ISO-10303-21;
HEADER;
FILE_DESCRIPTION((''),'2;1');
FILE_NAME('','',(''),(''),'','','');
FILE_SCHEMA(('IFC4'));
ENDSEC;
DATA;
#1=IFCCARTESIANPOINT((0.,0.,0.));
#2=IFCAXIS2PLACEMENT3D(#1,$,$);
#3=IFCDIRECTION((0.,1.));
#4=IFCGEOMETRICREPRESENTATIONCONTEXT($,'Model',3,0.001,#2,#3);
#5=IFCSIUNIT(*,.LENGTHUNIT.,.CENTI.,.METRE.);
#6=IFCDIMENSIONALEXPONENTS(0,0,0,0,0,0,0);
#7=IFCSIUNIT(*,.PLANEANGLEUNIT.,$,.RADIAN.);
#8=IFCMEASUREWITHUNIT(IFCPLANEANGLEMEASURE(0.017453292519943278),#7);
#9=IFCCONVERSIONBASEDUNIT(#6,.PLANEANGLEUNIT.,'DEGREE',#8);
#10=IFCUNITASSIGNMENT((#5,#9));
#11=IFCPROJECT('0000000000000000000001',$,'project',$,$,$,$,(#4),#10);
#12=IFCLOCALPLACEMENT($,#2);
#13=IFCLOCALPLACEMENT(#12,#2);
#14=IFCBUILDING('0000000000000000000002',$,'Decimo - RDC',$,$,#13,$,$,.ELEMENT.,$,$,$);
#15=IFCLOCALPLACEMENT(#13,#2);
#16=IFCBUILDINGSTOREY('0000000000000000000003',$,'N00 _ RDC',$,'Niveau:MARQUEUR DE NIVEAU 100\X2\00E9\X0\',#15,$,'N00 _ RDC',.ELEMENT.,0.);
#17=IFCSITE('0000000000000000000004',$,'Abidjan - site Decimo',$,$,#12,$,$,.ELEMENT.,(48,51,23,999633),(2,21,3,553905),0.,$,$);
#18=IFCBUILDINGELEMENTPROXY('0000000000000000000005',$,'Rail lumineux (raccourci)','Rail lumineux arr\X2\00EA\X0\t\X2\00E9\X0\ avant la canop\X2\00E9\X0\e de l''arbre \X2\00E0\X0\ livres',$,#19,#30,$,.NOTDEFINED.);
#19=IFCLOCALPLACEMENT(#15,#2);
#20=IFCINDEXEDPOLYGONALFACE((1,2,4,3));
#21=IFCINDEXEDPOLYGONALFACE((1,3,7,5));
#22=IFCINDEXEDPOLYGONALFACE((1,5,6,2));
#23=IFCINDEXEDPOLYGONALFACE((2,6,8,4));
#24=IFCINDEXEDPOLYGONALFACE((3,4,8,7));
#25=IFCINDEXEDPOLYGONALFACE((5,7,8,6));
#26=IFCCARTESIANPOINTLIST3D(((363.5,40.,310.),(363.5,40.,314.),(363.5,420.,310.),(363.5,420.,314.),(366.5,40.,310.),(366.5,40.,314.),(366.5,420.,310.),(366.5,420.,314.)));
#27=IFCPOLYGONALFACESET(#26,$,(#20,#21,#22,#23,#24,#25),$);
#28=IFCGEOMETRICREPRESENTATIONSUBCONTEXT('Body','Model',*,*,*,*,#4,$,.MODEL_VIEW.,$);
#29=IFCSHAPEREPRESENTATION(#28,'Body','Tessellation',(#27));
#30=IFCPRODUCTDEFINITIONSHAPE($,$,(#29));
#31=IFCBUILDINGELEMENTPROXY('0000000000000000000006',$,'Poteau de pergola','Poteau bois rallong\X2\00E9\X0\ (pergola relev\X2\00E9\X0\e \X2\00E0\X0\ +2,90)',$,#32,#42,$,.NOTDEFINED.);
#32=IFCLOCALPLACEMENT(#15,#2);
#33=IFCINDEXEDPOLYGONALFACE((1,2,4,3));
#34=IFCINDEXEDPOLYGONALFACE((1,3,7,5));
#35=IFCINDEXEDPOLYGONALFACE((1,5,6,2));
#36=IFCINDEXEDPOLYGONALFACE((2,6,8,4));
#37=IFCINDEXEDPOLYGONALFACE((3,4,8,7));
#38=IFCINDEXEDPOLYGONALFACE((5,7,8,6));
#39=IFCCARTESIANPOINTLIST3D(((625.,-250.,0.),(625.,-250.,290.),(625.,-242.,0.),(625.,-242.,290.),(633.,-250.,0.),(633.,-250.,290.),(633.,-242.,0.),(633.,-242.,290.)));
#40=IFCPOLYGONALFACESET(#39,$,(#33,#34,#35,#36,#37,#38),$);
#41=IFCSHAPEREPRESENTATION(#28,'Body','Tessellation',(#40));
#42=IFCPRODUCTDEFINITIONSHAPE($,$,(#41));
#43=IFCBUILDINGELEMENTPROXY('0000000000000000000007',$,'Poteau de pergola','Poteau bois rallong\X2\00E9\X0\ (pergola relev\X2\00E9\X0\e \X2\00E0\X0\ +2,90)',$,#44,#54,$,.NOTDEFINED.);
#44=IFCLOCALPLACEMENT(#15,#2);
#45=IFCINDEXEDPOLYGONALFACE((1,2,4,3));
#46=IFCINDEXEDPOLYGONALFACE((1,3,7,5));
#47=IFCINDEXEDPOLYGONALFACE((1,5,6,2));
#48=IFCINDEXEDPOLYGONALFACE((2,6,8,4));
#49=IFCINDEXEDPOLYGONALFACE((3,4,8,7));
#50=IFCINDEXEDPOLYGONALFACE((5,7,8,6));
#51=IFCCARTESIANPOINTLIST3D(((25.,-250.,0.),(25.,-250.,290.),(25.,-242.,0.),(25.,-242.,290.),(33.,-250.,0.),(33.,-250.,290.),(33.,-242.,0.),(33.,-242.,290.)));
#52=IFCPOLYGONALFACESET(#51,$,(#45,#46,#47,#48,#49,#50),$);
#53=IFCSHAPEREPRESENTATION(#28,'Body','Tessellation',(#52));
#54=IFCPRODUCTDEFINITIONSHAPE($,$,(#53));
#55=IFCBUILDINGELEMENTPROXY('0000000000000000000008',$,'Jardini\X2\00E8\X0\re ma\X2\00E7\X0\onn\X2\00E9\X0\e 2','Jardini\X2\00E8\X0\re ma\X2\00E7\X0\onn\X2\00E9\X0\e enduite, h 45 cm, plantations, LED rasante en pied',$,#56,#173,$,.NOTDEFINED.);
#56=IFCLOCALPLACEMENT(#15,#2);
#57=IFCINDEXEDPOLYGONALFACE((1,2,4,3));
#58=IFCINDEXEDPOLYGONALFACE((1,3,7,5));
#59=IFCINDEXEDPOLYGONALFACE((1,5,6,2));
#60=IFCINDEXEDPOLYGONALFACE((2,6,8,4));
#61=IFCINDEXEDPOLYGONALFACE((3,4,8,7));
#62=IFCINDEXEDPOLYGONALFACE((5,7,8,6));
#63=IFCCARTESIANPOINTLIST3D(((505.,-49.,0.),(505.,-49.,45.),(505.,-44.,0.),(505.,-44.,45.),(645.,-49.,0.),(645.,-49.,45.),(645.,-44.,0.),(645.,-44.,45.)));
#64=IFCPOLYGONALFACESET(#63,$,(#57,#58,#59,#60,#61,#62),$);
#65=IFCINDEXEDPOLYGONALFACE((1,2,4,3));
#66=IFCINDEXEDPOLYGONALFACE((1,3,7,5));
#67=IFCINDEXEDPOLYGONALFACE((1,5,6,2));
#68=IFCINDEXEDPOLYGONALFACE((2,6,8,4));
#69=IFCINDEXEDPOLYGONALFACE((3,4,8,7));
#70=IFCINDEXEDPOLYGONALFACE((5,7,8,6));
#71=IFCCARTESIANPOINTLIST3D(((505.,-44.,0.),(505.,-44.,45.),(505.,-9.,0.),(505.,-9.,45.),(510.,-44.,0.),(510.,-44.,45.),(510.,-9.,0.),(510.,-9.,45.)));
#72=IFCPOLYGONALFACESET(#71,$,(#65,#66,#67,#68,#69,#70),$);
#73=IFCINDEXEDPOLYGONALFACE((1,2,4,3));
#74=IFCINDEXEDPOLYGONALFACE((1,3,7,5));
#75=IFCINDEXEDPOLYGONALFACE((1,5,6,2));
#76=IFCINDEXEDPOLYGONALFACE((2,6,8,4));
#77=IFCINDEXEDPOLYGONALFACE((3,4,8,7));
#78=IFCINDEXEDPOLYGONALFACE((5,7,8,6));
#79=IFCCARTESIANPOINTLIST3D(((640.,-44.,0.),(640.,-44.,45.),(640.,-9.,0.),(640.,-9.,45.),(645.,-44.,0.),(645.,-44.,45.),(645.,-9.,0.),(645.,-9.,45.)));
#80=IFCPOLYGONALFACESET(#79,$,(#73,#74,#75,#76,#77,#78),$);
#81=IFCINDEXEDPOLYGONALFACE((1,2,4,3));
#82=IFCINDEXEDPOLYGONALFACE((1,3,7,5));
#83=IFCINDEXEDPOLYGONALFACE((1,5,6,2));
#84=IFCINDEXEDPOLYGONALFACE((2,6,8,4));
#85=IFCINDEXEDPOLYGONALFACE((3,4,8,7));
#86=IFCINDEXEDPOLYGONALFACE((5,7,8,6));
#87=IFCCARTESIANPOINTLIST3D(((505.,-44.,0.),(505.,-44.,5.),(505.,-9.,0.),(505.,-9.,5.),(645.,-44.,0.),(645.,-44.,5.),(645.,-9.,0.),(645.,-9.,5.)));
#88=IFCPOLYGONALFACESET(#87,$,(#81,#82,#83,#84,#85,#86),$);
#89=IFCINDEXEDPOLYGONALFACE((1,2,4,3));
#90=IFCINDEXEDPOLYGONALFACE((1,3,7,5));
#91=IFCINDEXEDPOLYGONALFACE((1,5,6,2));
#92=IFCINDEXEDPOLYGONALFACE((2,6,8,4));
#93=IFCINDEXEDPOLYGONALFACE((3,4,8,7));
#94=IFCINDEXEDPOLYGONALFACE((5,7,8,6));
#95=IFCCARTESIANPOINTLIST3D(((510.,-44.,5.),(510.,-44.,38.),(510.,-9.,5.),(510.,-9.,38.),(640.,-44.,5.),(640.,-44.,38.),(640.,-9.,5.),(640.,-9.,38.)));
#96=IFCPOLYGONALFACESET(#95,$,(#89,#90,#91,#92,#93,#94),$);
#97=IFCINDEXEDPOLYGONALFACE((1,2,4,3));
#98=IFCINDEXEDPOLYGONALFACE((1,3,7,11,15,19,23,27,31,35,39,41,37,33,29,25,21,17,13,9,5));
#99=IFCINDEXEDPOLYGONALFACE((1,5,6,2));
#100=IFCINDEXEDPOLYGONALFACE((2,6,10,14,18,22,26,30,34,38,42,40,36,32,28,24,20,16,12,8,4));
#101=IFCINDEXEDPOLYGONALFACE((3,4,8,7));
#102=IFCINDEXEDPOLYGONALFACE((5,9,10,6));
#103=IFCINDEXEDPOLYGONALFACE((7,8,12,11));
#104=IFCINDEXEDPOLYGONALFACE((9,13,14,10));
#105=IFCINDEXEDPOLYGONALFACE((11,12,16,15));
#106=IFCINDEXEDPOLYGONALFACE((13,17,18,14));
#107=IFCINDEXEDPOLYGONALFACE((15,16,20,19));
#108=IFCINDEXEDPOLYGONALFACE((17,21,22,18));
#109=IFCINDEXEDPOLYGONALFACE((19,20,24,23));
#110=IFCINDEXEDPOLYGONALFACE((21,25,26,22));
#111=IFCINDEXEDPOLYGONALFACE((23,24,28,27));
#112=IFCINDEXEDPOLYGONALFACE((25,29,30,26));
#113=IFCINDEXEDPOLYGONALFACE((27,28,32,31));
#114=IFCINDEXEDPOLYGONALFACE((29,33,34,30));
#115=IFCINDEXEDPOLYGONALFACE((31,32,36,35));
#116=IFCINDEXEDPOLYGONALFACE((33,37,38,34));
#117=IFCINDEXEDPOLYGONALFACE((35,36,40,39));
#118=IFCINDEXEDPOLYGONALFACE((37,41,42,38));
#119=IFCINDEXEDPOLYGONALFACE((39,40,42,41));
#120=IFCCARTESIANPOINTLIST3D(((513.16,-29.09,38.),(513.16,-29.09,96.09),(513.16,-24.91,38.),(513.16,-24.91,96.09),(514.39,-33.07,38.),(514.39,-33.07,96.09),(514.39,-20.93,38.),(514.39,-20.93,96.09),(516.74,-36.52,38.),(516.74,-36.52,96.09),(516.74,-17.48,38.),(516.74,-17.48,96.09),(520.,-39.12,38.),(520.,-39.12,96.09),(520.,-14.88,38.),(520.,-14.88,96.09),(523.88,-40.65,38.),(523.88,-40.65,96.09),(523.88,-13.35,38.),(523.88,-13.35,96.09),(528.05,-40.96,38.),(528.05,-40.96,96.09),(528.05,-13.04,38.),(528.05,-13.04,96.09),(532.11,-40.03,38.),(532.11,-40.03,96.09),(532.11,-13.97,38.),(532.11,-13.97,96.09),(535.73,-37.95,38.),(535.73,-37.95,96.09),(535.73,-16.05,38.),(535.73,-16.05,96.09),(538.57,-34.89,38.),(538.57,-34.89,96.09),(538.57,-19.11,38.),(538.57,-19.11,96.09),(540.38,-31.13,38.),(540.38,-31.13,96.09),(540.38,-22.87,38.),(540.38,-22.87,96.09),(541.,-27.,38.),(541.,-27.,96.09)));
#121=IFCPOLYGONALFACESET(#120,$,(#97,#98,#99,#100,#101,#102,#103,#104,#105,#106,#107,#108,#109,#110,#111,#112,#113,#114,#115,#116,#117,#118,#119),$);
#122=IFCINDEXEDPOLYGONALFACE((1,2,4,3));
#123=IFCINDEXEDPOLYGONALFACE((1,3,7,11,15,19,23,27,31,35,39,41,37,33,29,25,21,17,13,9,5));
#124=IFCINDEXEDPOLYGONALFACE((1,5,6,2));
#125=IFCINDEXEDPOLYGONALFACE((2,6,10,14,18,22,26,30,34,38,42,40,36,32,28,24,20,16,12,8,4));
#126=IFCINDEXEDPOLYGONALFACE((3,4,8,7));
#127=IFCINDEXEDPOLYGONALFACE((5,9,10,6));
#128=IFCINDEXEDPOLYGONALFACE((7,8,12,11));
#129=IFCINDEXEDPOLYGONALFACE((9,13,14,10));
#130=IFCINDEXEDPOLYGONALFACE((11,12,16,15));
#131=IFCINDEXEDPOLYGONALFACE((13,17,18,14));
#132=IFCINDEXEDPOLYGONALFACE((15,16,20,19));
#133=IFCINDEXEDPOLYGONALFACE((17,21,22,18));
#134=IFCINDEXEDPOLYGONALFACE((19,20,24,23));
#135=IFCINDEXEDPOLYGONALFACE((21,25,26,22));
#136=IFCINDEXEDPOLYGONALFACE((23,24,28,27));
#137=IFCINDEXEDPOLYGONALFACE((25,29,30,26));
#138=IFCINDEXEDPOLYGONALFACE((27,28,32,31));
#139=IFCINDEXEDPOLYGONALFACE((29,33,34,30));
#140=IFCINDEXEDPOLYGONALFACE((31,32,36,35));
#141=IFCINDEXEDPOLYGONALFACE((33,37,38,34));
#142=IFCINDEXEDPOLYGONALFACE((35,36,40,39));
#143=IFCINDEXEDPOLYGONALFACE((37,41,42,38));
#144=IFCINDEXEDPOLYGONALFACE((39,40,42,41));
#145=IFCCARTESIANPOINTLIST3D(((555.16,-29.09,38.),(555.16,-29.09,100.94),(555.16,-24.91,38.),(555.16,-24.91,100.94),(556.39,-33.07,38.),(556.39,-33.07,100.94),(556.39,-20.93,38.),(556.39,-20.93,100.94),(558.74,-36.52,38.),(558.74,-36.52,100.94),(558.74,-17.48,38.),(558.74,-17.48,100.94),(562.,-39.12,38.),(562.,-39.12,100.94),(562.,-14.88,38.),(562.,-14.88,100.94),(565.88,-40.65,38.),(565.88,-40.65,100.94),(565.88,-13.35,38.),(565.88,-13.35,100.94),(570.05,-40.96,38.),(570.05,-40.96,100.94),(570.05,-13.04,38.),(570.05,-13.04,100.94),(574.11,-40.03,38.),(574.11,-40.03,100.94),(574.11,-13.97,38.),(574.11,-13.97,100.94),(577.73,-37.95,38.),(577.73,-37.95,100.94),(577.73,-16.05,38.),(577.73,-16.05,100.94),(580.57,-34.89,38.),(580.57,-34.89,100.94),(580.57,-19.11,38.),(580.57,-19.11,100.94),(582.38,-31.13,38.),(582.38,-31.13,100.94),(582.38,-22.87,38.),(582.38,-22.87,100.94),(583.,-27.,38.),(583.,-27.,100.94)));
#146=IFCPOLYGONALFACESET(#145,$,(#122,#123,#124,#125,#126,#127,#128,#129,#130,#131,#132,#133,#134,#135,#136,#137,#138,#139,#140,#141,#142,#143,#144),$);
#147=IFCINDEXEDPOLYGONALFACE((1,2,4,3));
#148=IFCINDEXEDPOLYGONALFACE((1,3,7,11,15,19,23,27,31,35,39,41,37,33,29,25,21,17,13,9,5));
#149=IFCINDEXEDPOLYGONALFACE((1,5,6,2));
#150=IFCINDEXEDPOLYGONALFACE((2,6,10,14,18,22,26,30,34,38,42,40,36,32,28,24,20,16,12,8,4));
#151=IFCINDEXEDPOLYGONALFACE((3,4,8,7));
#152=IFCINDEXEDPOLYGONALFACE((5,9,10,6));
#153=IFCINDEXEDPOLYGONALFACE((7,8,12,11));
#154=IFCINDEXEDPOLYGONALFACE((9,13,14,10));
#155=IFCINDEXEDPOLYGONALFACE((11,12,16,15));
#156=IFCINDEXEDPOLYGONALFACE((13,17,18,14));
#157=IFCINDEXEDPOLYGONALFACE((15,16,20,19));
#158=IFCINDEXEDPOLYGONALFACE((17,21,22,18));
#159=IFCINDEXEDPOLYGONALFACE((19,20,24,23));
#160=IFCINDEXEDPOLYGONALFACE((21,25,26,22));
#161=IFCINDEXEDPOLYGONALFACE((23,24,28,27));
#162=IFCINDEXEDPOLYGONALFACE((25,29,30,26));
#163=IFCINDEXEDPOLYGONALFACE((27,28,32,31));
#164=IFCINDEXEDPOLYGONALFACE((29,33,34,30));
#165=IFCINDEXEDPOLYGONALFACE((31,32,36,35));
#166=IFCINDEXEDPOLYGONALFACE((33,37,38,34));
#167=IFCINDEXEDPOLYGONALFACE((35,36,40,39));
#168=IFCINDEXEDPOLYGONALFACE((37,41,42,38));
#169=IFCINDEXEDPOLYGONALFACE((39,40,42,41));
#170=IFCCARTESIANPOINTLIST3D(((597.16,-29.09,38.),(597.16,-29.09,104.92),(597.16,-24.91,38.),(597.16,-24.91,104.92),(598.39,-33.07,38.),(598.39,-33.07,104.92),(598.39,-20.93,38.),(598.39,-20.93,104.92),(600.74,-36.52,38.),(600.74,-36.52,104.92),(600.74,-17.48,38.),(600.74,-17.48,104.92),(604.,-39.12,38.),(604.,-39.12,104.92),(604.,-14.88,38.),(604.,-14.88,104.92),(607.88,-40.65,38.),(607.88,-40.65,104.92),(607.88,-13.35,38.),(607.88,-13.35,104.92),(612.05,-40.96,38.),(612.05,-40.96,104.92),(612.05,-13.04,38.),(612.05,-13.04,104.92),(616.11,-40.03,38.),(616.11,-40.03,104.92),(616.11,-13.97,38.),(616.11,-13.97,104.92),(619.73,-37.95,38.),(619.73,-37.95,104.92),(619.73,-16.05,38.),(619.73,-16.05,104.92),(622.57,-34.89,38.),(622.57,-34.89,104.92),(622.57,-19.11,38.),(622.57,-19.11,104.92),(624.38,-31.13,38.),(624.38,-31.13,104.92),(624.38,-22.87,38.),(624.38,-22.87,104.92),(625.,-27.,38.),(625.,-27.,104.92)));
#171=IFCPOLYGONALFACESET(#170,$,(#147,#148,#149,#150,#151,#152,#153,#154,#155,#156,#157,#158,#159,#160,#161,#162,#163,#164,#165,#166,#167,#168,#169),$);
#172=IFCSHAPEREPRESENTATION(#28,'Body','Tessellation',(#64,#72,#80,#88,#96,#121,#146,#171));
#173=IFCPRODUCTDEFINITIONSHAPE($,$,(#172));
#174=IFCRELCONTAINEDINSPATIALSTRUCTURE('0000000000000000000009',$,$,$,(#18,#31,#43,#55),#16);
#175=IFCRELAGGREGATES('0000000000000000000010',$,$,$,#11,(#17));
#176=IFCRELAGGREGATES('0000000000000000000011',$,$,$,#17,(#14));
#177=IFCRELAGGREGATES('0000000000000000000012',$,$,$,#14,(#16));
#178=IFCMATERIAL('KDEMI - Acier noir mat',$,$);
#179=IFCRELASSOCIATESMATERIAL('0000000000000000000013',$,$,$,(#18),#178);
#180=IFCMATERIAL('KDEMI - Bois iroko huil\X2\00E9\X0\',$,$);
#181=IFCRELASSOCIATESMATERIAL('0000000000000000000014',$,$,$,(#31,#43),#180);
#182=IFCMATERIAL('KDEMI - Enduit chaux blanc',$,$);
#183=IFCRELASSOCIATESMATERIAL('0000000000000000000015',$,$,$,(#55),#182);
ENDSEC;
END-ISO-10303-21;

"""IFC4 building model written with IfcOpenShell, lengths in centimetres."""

from ifc_helpers import new_model, entity, si_unit, converted_unit, direction, frame, frame_2d, origin, origin_with_axes, place, context, subcontext, project, spatial, rectangle, circle, extrude, material, element, save


model = new_model("IFC4")

# Units and contexts
model_context = context("Model", 3, precision=0.001, world=origin(), true_north=direction((0.0, 1.0)))
body_context = subcontext(model_context, "Body", "Model", "MODEL_VIEW")
ifc_project = project(units=[si_unit("LENGTHUNIT", "METRE", prefix="CENTI"), converted_unit("PLANEANGLEUNIT", "DEGREE", entity("IfcPlaneAngleMeasure", 0.017453292519943278), si_unit("PLANEANGLEUNIT", "RADIAN"), dimensions=[0, 0, 0, 0, 0, 0, 0])], contexts=[model_context])

# Site, building, storey
site_placement = place(None, origin())
site = spatial("IfcSite", under=ifc_project, at=site_placement, Name="Abidjan - site Decimo", CompositionType="ELEMENT", RefLatitude=(48, 51, 23, 999633), RefLongitude=(2, 21, 3, 553905), RefElevation=0.0)
building_placement = place(site_placement, origin())
building = spatial("IfcBuilding", under=site, at=building_placement, Name="Decimo - RDC", CompositionType="ELEMENT")
storey_placement = place(building_placement, origin())
storey = spatial("IfcBuildingStorey", under=building, at=storey_placement, Name="N00 _ RDC", ObjectType="Niveau:MARQUEUR DE NIVEAU 100é", LongName="N00 _ RDC", CompositionType="ELEMENT", Elevation=0.0)

# Shared definitions
ifc_material_1 = material(Name="KDEMI - Acier noir mat")

# Shared definitions
ifc_material_2 = material(Name="KDEMI - Bois iroko huilé")

# Building element proxies
proxy_1_placement = place(storey_placement, origin_with_axes())
element("IfcBuildingElementProxy", 1, at=proxy_1_placement, inside=storey, material=ifc_material_1, Name="Rail lumineux (raccourci)", Description="Rail lumineux arrêté avant la canopée de l'arbre à livres", PredefinedType="NOTDEFINED", context=body_context, shape_type="SweptSolid", body=[
    extrude(rectangle(XDim=3.0, YDim=380.0, at=frame_2d((365.0, 230.0))), frame((0.0, 0.0, 310.0)), (0.0, 0.0, 1.0), 4.0),
])
proxy_2_placement = place(storey_placement, origin_with_axes())
element("IfcBuildingElementProxy", 2, at=proxy_2_placement, inside=storey, material=ifc_material_2, Name="Poteau de pergola", Description="Poteau bois rallongé (pergola relevée à +2,90)", PredefinedType="NOTDEFINED", context=body_context, shape_type="SweptSolid", body=[
    extrude(rectangle(XDim=8.0, YDim=8.0, at=frame_2d((629.0, -246.0))), origin(), (0.0, 0.0, 1.0), 290.0),
])
proxy_3_placement = place(storey_placement, origin_with_axes())
element("IfcBuildingElementProxy", 3, at=proxy_3_placement, inside=storey, material=ifc_material_2, Name="Poteau de pergola", Description="Poteau bois rallongé (pergola relevée à +2,90)", PredefinedType="NOTDEFINED", context=body_context, shape_type="SweptSolid", body=[
    extrude(rectangle(XDim=8.0, YDim=8.0, at=frame_2d((29.0, -246.0))), origin(), (0.0, 0.0, 1.0), 290.0),
])
ifc_material_3 = material(Name="KDEMI - Enduit chaux blanc")
proxy_4_placement = place(storey_placement, origin_with_axes())
element("IfcBuildingElementProxy", 4, at=proxy_4_placement, inside=storey, material=ifc_material_3, Name="Jardinière maçonnée 2", Description="Jardinière maçonnée enduite, h 45 cm, plantations, LED rasante en pied", PredefinedType="NOTDEFINED", context=body_context, shape_type="SweptSolid", body=[
    extrude(rectangle(XDim=140.0, YDim=5.0, at=frame_2d((575.0, -46.5))), origin(), (0.0, 0.0, 1.0), 45.0),
    extrude(rectangle(XDim=5.0, YDim=35.0, at=frame_2d((507.5, -26.5))), origin(), (0.0, 0.0, 1.0), 45.0),
    extrude(rectangle(XDim=5.0, YDim=35.0, at=frame_2d((642.5, -26.5))), origin(), (0.0, 0.0, 1.0), 45.0),
    extrude(rectangle(XDim=140.0, YDim=35.0, at=frame_2d((575.0, -26.5))), origin(), (0.0, 0.0, 1.0), 5.0),
    extrude(rectangle(XDim=130.0, YDim=35.0, at=frame_2d((575.0, -26.5))), frame((0.0, 0.0, 5.0)), (0.0, 0.0, 1.0), 33.0),
    extrude(circle(Radius=14.0, at=frame_2d((527.0, -27.0))), frame((0.0, 0.0, 38.0)), (0.0, 0.0, 1.0), 58.09),
    extrude(circle(Radius=14.0, at=frame_2d((569.0, -27.0))), frame((0.0, 0.0, 38.0)), (0.0, 0.0, 1.0), 62.94),
    extrude(circle(Radius=14.0, at=frame_2d((611.0, -27.0))), frame((0.0, 0.0, 38.0)), (0.0, 0.0, 1.0), 66.92),
])

save(model, "model.ifc")
